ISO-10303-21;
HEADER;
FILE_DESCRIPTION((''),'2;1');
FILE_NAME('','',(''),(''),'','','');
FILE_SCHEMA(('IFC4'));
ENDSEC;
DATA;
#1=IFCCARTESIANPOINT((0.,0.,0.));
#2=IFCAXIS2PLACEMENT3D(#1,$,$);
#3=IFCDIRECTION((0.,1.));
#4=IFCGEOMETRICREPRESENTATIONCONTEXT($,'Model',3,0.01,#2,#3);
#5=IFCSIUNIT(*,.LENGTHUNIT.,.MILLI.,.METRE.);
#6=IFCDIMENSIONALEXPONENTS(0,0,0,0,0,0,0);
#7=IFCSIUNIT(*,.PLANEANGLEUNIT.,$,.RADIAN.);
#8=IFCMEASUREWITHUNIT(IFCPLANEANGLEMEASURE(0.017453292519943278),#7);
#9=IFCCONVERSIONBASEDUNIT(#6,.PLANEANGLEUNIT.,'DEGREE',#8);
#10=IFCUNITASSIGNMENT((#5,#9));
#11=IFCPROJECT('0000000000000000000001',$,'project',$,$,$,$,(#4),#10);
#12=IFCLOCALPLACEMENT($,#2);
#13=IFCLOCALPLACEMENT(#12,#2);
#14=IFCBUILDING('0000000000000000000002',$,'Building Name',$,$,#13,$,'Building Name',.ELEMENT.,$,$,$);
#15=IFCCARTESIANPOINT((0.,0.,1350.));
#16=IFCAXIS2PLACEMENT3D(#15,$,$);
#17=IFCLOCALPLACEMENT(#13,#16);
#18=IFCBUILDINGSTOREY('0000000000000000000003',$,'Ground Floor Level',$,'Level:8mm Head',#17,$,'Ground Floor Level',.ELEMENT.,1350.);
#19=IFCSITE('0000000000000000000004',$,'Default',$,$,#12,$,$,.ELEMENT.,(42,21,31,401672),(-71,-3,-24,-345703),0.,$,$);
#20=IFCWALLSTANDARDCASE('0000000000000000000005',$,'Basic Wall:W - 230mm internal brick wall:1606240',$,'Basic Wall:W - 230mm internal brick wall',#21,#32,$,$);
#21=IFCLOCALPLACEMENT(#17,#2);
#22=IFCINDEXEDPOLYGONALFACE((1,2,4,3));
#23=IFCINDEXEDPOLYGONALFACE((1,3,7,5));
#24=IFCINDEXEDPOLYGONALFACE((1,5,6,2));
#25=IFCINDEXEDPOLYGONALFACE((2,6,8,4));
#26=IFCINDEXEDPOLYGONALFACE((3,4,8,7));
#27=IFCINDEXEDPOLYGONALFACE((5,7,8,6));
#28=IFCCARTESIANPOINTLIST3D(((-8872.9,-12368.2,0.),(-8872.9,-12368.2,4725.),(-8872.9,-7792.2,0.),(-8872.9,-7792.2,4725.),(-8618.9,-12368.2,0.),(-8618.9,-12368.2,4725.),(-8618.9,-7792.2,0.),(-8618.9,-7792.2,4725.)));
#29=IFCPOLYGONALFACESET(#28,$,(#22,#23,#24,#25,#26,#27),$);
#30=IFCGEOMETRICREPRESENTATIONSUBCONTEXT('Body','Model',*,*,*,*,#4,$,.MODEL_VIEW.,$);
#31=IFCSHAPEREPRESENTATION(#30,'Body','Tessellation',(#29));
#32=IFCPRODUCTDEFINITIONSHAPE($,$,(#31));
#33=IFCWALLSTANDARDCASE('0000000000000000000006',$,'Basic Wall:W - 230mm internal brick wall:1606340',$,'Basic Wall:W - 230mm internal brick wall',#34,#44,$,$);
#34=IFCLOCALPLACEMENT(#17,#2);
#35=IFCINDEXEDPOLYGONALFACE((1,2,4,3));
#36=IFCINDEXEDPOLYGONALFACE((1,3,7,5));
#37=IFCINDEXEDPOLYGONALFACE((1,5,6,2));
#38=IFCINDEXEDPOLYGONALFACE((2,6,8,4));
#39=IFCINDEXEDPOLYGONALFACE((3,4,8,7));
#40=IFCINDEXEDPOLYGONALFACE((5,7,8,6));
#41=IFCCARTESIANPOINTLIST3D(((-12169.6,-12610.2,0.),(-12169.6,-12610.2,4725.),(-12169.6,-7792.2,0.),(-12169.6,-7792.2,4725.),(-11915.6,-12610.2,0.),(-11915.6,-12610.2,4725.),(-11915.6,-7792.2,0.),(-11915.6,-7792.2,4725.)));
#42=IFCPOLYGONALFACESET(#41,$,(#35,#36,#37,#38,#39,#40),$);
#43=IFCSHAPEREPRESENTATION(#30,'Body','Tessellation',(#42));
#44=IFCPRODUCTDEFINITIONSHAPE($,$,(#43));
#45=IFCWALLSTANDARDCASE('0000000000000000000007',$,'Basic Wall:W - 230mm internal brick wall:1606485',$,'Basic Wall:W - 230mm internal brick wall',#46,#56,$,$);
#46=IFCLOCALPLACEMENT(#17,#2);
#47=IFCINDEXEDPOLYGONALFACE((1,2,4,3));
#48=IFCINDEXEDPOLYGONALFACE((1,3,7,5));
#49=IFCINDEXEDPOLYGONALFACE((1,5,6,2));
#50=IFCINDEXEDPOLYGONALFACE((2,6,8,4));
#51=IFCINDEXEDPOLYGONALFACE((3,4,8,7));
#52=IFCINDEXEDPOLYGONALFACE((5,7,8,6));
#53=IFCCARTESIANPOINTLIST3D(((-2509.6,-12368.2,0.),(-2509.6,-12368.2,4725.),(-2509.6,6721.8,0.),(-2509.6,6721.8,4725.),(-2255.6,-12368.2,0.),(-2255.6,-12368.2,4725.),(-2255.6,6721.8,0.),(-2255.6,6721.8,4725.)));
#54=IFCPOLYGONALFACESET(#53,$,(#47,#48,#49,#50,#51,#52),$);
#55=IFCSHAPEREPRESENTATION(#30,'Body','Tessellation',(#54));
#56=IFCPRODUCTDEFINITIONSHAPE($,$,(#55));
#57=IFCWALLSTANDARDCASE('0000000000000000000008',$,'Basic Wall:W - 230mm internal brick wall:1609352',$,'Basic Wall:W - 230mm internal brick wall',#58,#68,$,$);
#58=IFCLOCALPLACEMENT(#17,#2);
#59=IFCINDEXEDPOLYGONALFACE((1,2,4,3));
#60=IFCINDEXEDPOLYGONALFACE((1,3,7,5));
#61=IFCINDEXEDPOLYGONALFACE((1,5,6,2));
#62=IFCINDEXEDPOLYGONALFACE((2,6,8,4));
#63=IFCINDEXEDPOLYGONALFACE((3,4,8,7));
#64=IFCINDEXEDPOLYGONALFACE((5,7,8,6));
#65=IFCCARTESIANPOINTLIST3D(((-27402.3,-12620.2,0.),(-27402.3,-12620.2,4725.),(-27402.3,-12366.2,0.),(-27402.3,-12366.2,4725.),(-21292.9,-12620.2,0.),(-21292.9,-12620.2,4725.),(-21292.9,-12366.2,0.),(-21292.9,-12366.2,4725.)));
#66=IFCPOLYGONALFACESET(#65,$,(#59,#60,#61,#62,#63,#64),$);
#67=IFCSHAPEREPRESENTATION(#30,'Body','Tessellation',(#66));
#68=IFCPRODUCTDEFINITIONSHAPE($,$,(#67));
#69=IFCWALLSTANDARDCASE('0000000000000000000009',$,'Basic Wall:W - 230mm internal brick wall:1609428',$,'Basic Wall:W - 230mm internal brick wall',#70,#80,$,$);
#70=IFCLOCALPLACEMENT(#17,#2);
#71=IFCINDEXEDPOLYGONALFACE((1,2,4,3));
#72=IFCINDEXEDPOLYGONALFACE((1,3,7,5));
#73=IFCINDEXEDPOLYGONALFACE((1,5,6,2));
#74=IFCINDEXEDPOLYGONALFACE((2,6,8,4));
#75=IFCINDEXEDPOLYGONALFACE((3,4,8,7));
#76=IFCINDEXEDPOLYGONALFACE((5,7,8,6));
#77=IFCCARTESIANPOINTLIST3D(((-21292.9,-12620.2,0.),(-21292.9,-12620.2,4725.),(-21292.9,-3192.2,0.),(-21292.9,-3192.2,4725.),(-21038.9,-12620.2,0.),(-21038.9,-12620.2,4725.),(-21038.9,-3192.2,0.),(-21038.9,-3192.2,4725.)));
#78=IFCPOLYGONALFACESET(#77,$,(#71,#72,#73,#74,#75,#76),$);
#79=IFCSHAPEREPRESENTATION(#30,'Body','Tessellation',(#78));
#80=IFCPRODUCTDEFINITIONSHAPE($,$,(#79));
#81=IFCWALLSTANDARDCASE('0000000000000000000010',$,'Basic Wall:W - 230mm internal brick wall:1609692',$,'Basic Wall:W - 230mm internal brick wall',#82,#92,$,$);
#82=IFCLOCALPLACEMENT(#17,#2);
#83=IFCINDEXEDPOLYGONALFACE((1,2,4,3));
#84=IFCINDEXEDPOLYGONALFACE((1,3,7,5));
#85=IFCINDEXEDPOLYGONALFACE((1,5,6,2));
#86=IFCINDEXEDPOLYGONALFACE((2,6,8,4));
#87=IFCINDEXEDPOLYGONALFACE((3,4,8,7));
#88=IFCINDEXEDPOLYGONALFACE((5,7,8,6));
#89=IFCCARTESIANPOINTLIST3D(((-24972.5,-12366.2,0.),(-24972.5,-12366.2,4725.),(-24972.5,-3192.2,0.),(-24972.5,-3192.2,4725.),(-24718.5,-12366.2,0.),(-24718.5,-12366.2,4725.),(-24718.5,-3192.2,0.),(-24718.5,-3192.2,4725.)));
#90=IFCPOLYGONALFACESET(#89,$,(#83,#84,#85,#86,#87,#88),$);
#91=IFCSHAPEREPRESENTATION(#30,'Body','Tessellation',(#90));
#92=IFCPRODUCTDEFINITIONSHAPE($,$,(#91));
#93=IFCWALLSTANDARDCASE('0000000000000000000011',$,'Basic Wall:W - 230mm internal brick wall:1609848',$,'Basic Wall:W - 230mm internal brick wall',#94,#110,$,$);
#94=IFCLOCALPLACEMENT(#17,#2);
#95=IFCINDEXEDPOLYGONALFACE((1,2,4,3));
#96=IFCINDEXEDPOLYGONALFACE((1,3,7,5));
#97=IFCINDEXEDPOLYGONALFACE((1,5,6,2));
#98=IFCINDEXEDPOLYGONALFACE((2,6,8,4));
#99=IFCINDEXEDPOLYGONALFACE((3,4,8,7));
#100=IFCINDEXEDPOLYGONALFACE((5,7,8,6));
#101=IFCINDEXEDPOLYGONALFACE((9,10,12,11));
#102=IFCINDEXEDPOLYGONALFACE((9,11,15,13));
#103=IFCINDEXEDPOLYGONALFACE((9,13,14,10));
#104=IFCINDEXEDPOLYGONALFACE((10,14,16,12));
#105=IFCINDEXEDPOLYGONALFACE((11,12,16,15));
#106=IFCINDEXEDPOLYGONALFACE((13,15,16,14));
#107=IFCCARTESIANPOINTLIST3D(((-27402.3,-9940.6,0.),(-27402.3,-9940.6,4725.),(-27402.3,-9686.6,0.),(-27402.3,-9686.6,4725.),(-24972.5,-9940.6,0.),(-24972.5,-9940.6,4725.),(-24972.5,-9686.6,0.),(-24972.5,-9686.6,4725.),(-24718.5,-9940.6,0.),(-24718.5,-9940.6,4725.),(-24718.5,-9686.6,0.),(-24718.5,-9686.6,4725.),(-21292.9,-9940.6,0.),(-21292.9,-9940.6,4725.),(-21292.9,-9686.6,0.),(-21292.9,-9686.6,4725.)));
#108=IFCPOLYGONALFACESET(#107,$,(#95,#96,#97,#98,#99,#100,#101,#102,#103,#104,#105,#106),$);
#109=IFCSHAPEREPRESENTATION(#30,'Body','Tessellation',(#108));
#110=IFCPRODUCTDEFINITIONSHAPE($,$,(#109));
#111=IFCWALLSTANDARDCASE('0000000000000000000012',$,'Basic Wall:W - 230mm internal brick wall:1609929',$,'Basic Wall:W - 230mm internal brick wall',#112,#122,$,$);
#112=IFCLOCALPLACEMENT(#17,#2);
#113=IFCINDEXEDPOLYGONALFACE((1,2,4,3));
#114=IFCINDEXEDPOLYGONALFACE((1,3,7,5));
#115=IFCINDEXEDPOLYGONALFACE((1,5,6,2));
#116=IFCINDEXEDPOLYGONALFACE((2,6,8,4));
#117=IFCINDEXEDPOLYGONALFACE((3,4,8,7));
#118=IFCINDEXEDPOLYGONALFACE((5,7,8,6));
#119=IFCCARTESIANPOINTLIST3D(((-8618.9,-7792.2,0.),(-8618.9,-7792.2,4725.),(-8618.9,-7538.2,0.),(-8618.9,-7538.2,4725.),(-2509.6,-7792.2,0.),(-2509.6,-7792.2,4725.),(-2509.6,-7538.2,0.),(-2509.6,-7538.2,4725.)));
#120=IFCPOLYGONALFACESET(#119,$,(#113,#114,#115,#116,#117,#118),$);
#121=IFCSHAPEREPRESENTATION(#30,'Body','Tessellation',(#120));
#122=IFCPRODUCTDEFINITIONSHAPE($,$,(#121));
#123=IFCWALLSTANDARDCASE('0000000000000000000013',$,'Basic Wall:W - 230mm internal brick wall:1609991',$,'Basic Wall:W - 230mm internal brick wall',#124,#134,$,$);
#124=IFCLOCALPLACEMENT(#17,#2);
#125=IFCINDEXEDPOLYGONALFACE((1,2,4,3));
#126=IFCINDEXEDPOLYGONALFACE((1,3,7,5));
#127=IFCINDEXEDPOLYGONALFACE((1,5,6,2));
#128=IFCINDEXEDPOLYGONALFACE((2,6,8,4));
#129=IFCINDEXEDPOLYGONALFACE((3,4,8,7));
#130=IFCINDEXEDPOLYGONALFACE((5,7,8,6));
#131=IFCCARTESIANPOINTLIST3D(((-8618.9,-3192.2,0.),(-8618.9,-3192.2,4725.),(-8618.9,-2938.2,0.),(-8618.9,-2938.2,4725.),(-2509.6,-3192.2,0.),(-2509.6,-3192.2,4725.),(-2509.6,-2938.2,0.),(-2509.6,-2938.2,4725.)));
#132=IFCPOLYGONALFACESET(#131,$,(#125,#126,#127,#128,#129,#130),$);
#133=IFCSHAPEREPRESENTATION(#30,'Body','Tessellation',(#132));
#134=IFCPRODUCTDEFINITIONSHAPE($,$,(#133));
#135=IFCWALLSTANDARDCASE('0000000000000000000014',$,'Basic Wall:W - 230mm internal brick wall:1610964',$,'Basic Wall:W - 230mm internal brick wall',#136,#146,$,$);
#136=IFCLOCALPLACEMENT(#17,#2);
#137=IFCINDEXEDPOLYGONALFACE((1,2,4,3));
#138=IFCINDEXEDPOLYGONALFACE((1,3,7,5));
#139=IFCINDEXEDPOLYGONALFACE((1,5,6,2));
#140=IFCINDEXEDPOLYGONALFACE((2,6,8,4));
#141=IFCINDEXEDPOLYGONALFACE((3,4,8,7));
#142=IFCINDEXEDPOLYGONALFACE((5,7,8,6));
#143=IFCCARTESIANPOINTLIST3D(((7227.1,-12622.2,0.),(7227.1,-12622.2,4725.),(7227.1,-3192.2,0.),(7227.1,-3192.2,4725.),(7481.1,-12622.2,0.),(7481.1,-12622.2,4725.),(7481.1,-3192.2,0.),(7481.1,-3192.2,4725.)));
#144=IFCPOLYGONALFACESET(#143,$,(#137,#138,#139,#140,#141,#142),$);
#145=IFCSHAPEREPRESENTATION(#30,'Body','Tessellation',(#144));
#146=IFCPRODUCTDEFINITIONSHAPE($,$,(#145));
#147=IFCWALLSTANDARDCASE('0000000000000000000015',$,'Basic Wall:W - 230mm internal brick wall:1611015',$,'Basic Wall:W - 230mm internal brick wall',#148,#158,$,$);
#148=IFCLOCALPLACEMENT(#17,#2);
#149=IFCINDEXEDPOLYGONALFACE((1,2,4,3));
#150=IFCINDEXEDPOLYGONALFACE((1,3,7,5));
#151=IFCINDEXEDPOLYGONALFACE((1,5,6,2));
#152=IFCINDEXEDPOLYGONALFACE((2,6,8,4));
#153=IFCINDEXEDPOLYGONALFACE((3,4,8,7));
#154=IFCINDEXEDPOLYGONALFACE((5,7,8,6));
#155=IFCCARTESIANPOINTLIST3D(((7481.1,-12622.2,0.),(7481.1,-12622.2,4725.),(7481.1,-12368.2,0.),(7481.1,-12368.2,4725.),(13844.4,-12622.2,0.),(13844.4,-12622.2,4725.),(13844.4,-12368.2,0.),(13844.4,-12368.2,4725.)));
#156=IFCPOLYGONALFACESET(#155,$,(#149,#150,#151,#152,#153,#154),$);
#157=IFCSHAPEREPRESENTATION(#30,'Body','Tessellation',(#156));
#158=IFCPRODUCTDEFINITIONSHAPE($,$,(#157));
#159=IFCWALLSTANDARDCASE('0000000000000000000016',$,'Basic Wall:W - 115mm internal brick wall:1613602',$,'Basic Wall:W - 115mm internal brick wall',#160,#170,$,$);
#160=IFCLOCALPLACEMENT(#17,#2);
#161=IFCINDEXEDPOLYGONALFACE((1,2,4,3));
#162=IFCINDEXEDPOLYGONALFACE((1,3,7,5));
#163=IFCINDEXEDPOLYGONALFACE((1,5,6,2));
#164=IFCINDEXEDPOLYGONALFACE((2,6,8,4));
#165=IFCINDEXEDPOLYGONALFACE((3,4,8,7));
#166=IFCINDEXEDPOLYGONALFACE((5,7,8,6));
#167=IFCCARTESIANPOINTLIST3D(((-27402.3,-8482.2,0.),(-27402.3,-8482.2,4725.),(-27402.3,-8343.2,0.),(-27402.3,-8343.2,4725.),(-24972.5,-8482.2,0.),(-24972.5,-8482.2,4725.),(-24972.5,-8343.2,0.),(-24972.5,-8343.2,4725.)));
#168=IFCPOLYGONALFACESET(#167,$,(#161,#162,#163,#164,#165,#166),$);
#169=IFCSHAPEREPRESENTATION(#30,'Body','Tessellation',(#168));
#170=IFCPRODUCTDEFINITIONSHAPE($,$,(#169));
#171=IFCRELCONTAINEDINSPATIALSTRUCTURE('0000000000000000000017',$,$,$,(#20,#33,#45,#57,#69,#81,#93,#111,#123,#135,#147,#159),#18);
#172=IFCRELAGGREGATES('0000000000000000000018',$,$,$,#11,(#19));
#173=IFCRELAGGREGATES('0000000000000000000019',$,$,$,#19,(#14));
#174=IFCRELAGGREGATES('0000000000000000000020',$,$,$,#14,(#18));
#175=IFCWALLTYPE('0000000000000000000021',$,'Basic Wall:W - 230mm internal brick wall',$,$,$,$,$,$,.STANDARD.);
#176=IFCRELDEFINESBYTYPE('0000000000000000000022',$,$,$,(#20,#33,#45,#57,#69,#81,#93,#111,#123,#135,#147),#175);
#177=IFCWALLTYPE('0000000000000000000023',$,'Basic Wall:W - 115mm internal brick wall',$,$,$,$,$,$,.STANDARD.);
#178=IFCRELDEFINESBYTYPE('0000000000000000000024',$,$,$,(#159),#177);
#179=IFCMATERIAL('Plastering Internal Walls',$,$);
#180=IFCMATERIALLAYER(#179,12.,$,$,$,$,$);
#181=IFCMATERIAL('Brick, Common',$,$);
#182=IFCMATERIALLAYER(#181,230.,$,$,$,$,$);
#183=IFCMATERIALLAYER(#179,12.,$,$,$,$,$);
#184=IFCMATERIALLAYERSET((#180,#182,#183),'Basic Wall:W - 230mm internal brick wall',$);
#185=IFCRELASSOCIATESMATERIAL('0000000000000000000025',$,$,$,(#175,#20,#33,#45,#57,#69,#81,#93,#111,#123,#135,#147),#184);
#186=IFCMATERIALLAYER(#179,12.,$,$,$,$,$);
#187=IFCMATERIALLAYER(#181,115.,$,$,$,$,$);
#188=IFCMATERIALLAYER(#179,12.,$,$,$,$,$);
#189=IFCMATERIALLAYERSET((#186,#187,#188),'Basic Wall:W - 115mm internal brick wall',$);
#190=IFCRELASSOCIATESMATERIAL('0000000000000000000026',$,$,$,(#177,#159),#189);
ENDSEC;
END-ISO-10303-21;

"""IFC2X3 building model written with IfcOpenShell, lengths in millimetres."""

from ifc_helpers import new_model, entity, si_unit, converted_unit, direction, frame, frame_2d, origin, place, context, subcontext, project, spatial, rectangle, extrude, material, layer, layer_set, layer_usage, type_object, element, save


model = new_model("IFC2X3")

# Units and contexts
model_context = context("Model", 3, precision=0.01, world=origin(), true_north=direction((0.0, 1.0)))
body_context = subcontext(model_context, "Body", "Model", "MODEL_VIEW")
ifc_project = project(units=[si_unit("LENGTHUNIT", "METRE", prefix="MILLI"), converted_unit("PLANEANGLEUNIT", "DEGREE", entity("IfcPlaneAngleMeasure", 0.017453292519943278), si_unit("PLANEANGLEUNIT", "RADIAN"), dimensions=[0, 0, 0, 0, 0, 0, 0])], contexts=[model_context])

# Site, building, storey
site_placement = place(None, origin())
site = spatial("IfcSite", under=ifc_project, at=site_placement, Name="Default", CompositionType="ELEMENT", RefLatitude=(42, 21, 31, 401672), RefLongitude=(-71, -3, -24, -345703), RefElevation=0.0)
building_placement = place(site_placement, origin())
building = spatial("IfcBuilding", under=site, at=building_placement, Name="Building Name", LongName="Building Name", CompositionType="ELEMENT")
storey_placement = place(building_placement, frame((0.0, 0.0, 1350.0)))
storey = spatial("IfcBuildingStorey", under=building, at=storey_placement, Name="Ground Floor Level", ObjectType="Level:8mm Head", LongName="Ground Floor Level", CompositionType="ELEMENT", Elevation=1350.0)

# Walls
ifc_material_1 = material(Name="Brick, Common")
ifc_material_2 = material(Name="Plastering Internal Walls")
ifc_layer_1 = layer(ifc_material_2, 12.0)
ifc_layer_2 = layer(ifc_material_1, 230.0)
ifc_layer_3 = layer(ifc_material_2, 12.0)
ifc_layer_set_1 = layer_set([ifc_layer_1, ifc_layer_2, ifc_layer_3], Name="Basic Wall:W - 230mm internal brick wall")
wall_type_1 = type_object("IfcWallType", Name="Basic Wall:W - 230mm internal brick wall", PredefinedType="STANDARD", material=ifc_layer_set_1)
ifc_layer_usage_1 = layer_usage(ifc_layer_set_1, "AXIS2", "NEGATIVE", 127.0)
wall_1_placement = place(storey_placement, frame((-8745.9, -12368.2, 0.0), z_axis=(0.0, 0.0, 1.0), x_axis=(0.0, 1.0, 0.0)))
element("IfcWallStandardCase", 1, at=wall_1_placement, inside=storey, type_object=wall_type_1, material=ifc_layer_usage_1, Name="Basic Wall:W - 230mm internal brick wall:1606240", ObjectType="Basic Wall:W - 230mm internal brick wall", context=body_context, shape_type="SweptSolid", body=[
    extrude(rectangle(XDim=4576.0, YDim=254.0, at=frame_2d((2288.0, 0.0), x_axis=(-1.0, 0.0))), origin(), (0.0, 0.0, 1.0), 4725.0),
])
ifc_layer_usage_2 = layer_usage(ifc_layer_set_1, "AXIS2", "NEGATIVE", 127.0)
wall_2_placement = place(storey_placement, frame((-12042.6, -7792.2, 0.0), z_axis=(0.0, 0.0, 1.0), x_axis=(0.0, -1.0, 0.0)))
element("IfcWallStandardCase", 2, at=wall_2_placement, inside=storey, type_object=wall_type_1, material=ifc_layer_usage_2, Name="Basic Wall:W - 230mm internal brick wall:1606340", ObjectType="Basic Wall:W - 230mm internal brick wall", context=body_context, shape_type="SweptSolid", body=[
    extrude(rectangle(XDim=4818.0, YDim=254.0, at=frame_2d((2409.0, 0.0), x_axis=(-1.0, 0.0))), origin(), (0.0, 0.0, 1.0), 4725.0),
])
ifc_layer_usage_3 = layer_usage(ifc_layer_set_1, "AXIS2", "NEGATIVE", 127.0)
wall_3_placement = place(storey_placement, frame((-2382.6, -12368.2, 0.0), z_axis=(0.0, 0.0, 1.0), x_axis=(0.0, 1.0, 0.0)))
element("IfcWallStandardCase", 3, at=wall_3_placement, inside=storey, type_object=wall_type_1, material=ifc_layer_usage_3, Name="Basic Wall:W - 230mm internal brick wall:1606485", ObjectType="Basic Wall:W - 230mm internal brick wall", context=body_context, shape_type="SweptSolid", body=[
    extrude(rectangle(XDim=19090.0, YDim=254.0, at=frame_2d((9545.0, 0.0), x_axis=(-1.0, 0.0))), origin(), (0.0, 0.0, 1.0), 4725.0),
])
ifc_layer_usage_4 = layer_usage(ifc_layer_set_1, "AXIS2", "NEGATIVE", 127.0)
wall_4_placement = place(storey_placement, frame((-27402.3, -12493.2, 0.0)))
element("IfcWallStandardCase", 4, at=wall_4_placement, inside=storey, type_object=wall_type_1, material=ifc_layer_usage_4, Name="Basic Wall:W - 230mm internal brick wall:1609352", ObjectType="Basic Wall:W - 230mm internal brick wall", context=body_context, shape_type="SweptSolid", body=[
    extrude(rectangle(XDim=6109.3, YDim=254.0, at=frame_2d((3054.7, 0.0), x_axis=(-1.0, 0.0))), origin(), (0.0, 0.0, 1.0), 4725.0),
])
ifc_layer_usage_5 = layer_usage(ifc_layer_set_1, "AXIS2", "NEGATIVE", 127.0)
wall_5_placement = place(storey_placement, frame((-21165.9, -12620.2, 0.0), z_axis=(0.0, 0.0, 1.0), x_axis=(0.0, 1.0, 0.0)))
element("IfcWallStandardCase", 5, at=wall_5_placement, inside=storey, type_object=wall_type_1, material=ifc_layer_usage_5, Name="Basic Wall:W - 230mm internal brick wall:1609428", ObjectType="Basic Wall:W - 230mm internal brick wall", context=body_context, shape_type="SweptSolid", body=[
    extrude(rectangle(XDim=9428.0, YDim=254.0, at=frame_2d((4714.0, 0.0), x_axis=(-1.0, 0.0))), origin(), (0.0, 0.0, 1.0), 4725.0),
])
ifc_layer_usage_6 = layer_usage(ifc_layer_set_1, "AXIS2", "NEGATIVE", 127.0)
wall_6_placement = place(storey_placement, frame((-24845.5, -12366.2, 0.0), z_axis=(0.0, 0.0, 1.0), x_axis=(0.0, 1.0, 0.0)))
element("IfcWallStandardCase", 6, at=wall_6_placement, inside=storey, type_object=wall_type_1, material=ifc_layer_usage_6, Name="Basic Wall:W - 230mm internal brick wall:1609692", ObjectType="Basic Wall:W - 230mm internal brick wall", context=body_context, shape_type="SweptSolid", body=[
    extrude(rectangle(XDim=9174.0, YDim=254.0, at=frame_2d((4587.0, 0.0), x_axis=(-1.0, 0.0))), origin(), (0.0, 0.0, 1.0), 4725.0),
])

# Wall, opening
ifc_layer_usage_7 = layer_usage(ifc_layer_set_1, "AXIS2", "NEGATIVE", 127.0)
wall_7_placement = place(storey_placement, frame((-21292.9, -9813.6, 0.0), z_axis=(0.0, 0.0, 1.0), x_axis=(-1.0, 0.0, 0.0)))
wall_7 = element("IfcWallStandardCase", 7, at=wall_7_placement, inside=storey, type_object=wall_type_1, material=ifc_layer_usage_7, Name="Basic Wall:W - 230mm internal brick wall:1609848", ObjectType="Basic Wall:W - 230mm internal brick wall", context=body_context, shape_type="SweptSolid", body=[
    extrude(rectangle(XDim=254.0, YDim=6109.3, at=frame_2d((3054.7, 0.0), x_axis=(0.0, -1.0))), origin(), (0.0, 0.0, 1.0), 4725.0),
])
opening_placement = place(storey_placement, frame((-21292.9, -9813.6, 0.0), z_axis=(0.0, 0.0, 1.0), x_axis=(-1.0, 0.0, 0.0)))
element("IfcOpeningElement", 8, at=opening_placement, cuts=wall_7, ObjectType="Opening", context=body_context, shape_type="SweptSolid", body=[
    extrude(rectangle(XDim=4725.0, YDim=254.0, at=frame_2d((0.0, 0.0), x_axis=(1.0, 0.0))), frame((3679.6, 0.0, 2362.5), z_axis=(-1.0, 0.0, 0.0), x_axis=(0.0, 0.0, 1.0)), (0.0, 0.0, 1.0), 254.0),
])

# Walls
ifc_layer_usage_8 = layer_usage(ifc_layer_set_1, "AXIS2", "NEGATIVE", 127.0)
wall_8_placement = place(storey_placement, frame((-2509.6, -7665.2, 0.0), z_axis=(0.0, 0.0, 1.0), x_axis=(-1.0, 0.0, 0.0)))
element("IfcWallStandardCase", 9, at=wall_8_placement, inside=storey, type_object=wall_type_1, material=ifc_layer_usage_8, Name="Basic Wall:W - 230mm internal brick wall:1609929", ObjectType="Basic Wall:W - 230mm internal brick wall", context=body_context, shape_type="SweptSolid", body=[
    extrude(rectangle(XDim=6109.3, YDim=254.0, at=frame_2d((3054.7, 0.0), x_axis=(-1.0, 0.0))), origin(), (0.0, 0.0, 1.0), 4725.0),
])
ifc_layer_usage_9 = layer_usage(ifc_layer_set_1, "AXIS2", "NEGATIVE", 127.0)
wall_9_placement = place(storey_placement, frame((-2509.6, -3065.2, 0.0), z_axis=(0.0, 0.0, 1.0), x_axis=(-1.0, 0.0, 0.0)))
element("IfcWallStandardCase", 10, at=wall_9_placement, inside=storey, type_object=wall_type_1, material=ifc_layer_usage_9, Name="Basic Wall:W - 230mm internal brick wall:1609991", ObjectType="Basic Wall:W - 230mm internal brick wall", context=body_context, shape_type="SweptSolid", body=[
    extrude(rectangle(XDim=6109.3, YDim=254.0, at=frame_2d((3054.7, 0.0), x_axis=(-1.0, 0.0))), origin(), (0.0, 0.0, 1.0), 4725.0),
])
ifc_layer_usage_10 = layer_usage(ifc_layer_set_1, "AXIS2", "NEGATIVE", 127.0)
wall_10_placement = place(storey_placement, frame((7354.1, -3192.2, 0.0), z_axis=(0.0, 0.0, 1.0), x_axis=(0.0, -1.0, 0.0)))
element("IfcWallStandardCase", 11, at=wall_10_placement, inside=storey, type_object=wall_type_1, material=ifc_layer_usage_10, Name="Basic Wall:W - 230mm internal brick wall:1610964", ObjectType="Basic Wall:W - 230mm internal brick wall", context=body_context, shape_type="SweptSolid", body=[
    extrude(rectangle(XDim=9430.0, YDim=254.0, at=frame_2d((4715.0, 0.0), x_axis=(-1.0, 0.0))), origin(), (0.0, 0.0, 1.0), 4725.0),
])
ifc_layer_usage_11 = layer_usage(ifc_layer_set_1, "AXIS2", "NEGATIVE", 127.0)
wall_11_placement = place(storey_placement, frame((7481.1, -12495.2, 0.0)))
element("IfcWallStandardCase", 12, at=wall_11_placement, inside=storey, type_object=wall_type_1, material=ifc_layer_usage_11, Name="Basic Wall:W - 230mm internal brick wall:1611015", ObjectType="Basic Wall:W - 230mm internal brick wall", context=body_context, shape_type="SweptSolid", body=[
    extrude(rectangle(XDim=6363.3, YDim=254.0, at=frame_2d((3181.7, 0.0), x_axis=(-1.0, 0.0))), origin(), (0.0, 0.0, 1.0), 4725.0),
])
ifc_layer_4 = layer(ifc_material_2, 12.0)
ifc_layer_5 = layer(ifc_material_1, 115.0)
ifc_layer_6 = layer(ifc_material_2, 12.0)
ifc_layer_set_2 = layer_set([ifc_layer_4, ifc_layer_5, ifc_layer_6], Name="Basic Wall:W - 115mm internal brick wall")
ifc_layer_usage_12 = layer_usage(ifc_layer_set_2, "AXIS2", "NEGATIVE", 69.5)
wall_type_2 = type_object("IfcWallType", Name="Basic Wall:W - 115mm internal brick wall", PredefinedType="STANDARD", material=ifc_layer_set_2)
wall_12_placement = place(storey_placement, frame((-24972.5, -8412.7, 0.0), z_axis=(0.0, 0.0, 1.0), x_axis=(-1.0, 0.0, 0.0)))
element("IfcWallStandardCase", 13, at=wall_12_placement, inside=storey, type_object=wall_type_2, material=ifc_layer_usage_12, Name="Basic Wall:W - 115mm internal brick wall:1613602", ObjectType="Basic Wall:W - 115mm internal brick wall", context=body_context, shape_type="SweptSolid", body=[
    extrude(rectangle(XDim=2429.8, YDim=139.0, at=frame_2d((1214.9, 0.0), x_axis=(-1.0, 0.0))), origin(), (0.0, 0.0, 1.0), 4725.0),
])

save(model, "model.ifc")
